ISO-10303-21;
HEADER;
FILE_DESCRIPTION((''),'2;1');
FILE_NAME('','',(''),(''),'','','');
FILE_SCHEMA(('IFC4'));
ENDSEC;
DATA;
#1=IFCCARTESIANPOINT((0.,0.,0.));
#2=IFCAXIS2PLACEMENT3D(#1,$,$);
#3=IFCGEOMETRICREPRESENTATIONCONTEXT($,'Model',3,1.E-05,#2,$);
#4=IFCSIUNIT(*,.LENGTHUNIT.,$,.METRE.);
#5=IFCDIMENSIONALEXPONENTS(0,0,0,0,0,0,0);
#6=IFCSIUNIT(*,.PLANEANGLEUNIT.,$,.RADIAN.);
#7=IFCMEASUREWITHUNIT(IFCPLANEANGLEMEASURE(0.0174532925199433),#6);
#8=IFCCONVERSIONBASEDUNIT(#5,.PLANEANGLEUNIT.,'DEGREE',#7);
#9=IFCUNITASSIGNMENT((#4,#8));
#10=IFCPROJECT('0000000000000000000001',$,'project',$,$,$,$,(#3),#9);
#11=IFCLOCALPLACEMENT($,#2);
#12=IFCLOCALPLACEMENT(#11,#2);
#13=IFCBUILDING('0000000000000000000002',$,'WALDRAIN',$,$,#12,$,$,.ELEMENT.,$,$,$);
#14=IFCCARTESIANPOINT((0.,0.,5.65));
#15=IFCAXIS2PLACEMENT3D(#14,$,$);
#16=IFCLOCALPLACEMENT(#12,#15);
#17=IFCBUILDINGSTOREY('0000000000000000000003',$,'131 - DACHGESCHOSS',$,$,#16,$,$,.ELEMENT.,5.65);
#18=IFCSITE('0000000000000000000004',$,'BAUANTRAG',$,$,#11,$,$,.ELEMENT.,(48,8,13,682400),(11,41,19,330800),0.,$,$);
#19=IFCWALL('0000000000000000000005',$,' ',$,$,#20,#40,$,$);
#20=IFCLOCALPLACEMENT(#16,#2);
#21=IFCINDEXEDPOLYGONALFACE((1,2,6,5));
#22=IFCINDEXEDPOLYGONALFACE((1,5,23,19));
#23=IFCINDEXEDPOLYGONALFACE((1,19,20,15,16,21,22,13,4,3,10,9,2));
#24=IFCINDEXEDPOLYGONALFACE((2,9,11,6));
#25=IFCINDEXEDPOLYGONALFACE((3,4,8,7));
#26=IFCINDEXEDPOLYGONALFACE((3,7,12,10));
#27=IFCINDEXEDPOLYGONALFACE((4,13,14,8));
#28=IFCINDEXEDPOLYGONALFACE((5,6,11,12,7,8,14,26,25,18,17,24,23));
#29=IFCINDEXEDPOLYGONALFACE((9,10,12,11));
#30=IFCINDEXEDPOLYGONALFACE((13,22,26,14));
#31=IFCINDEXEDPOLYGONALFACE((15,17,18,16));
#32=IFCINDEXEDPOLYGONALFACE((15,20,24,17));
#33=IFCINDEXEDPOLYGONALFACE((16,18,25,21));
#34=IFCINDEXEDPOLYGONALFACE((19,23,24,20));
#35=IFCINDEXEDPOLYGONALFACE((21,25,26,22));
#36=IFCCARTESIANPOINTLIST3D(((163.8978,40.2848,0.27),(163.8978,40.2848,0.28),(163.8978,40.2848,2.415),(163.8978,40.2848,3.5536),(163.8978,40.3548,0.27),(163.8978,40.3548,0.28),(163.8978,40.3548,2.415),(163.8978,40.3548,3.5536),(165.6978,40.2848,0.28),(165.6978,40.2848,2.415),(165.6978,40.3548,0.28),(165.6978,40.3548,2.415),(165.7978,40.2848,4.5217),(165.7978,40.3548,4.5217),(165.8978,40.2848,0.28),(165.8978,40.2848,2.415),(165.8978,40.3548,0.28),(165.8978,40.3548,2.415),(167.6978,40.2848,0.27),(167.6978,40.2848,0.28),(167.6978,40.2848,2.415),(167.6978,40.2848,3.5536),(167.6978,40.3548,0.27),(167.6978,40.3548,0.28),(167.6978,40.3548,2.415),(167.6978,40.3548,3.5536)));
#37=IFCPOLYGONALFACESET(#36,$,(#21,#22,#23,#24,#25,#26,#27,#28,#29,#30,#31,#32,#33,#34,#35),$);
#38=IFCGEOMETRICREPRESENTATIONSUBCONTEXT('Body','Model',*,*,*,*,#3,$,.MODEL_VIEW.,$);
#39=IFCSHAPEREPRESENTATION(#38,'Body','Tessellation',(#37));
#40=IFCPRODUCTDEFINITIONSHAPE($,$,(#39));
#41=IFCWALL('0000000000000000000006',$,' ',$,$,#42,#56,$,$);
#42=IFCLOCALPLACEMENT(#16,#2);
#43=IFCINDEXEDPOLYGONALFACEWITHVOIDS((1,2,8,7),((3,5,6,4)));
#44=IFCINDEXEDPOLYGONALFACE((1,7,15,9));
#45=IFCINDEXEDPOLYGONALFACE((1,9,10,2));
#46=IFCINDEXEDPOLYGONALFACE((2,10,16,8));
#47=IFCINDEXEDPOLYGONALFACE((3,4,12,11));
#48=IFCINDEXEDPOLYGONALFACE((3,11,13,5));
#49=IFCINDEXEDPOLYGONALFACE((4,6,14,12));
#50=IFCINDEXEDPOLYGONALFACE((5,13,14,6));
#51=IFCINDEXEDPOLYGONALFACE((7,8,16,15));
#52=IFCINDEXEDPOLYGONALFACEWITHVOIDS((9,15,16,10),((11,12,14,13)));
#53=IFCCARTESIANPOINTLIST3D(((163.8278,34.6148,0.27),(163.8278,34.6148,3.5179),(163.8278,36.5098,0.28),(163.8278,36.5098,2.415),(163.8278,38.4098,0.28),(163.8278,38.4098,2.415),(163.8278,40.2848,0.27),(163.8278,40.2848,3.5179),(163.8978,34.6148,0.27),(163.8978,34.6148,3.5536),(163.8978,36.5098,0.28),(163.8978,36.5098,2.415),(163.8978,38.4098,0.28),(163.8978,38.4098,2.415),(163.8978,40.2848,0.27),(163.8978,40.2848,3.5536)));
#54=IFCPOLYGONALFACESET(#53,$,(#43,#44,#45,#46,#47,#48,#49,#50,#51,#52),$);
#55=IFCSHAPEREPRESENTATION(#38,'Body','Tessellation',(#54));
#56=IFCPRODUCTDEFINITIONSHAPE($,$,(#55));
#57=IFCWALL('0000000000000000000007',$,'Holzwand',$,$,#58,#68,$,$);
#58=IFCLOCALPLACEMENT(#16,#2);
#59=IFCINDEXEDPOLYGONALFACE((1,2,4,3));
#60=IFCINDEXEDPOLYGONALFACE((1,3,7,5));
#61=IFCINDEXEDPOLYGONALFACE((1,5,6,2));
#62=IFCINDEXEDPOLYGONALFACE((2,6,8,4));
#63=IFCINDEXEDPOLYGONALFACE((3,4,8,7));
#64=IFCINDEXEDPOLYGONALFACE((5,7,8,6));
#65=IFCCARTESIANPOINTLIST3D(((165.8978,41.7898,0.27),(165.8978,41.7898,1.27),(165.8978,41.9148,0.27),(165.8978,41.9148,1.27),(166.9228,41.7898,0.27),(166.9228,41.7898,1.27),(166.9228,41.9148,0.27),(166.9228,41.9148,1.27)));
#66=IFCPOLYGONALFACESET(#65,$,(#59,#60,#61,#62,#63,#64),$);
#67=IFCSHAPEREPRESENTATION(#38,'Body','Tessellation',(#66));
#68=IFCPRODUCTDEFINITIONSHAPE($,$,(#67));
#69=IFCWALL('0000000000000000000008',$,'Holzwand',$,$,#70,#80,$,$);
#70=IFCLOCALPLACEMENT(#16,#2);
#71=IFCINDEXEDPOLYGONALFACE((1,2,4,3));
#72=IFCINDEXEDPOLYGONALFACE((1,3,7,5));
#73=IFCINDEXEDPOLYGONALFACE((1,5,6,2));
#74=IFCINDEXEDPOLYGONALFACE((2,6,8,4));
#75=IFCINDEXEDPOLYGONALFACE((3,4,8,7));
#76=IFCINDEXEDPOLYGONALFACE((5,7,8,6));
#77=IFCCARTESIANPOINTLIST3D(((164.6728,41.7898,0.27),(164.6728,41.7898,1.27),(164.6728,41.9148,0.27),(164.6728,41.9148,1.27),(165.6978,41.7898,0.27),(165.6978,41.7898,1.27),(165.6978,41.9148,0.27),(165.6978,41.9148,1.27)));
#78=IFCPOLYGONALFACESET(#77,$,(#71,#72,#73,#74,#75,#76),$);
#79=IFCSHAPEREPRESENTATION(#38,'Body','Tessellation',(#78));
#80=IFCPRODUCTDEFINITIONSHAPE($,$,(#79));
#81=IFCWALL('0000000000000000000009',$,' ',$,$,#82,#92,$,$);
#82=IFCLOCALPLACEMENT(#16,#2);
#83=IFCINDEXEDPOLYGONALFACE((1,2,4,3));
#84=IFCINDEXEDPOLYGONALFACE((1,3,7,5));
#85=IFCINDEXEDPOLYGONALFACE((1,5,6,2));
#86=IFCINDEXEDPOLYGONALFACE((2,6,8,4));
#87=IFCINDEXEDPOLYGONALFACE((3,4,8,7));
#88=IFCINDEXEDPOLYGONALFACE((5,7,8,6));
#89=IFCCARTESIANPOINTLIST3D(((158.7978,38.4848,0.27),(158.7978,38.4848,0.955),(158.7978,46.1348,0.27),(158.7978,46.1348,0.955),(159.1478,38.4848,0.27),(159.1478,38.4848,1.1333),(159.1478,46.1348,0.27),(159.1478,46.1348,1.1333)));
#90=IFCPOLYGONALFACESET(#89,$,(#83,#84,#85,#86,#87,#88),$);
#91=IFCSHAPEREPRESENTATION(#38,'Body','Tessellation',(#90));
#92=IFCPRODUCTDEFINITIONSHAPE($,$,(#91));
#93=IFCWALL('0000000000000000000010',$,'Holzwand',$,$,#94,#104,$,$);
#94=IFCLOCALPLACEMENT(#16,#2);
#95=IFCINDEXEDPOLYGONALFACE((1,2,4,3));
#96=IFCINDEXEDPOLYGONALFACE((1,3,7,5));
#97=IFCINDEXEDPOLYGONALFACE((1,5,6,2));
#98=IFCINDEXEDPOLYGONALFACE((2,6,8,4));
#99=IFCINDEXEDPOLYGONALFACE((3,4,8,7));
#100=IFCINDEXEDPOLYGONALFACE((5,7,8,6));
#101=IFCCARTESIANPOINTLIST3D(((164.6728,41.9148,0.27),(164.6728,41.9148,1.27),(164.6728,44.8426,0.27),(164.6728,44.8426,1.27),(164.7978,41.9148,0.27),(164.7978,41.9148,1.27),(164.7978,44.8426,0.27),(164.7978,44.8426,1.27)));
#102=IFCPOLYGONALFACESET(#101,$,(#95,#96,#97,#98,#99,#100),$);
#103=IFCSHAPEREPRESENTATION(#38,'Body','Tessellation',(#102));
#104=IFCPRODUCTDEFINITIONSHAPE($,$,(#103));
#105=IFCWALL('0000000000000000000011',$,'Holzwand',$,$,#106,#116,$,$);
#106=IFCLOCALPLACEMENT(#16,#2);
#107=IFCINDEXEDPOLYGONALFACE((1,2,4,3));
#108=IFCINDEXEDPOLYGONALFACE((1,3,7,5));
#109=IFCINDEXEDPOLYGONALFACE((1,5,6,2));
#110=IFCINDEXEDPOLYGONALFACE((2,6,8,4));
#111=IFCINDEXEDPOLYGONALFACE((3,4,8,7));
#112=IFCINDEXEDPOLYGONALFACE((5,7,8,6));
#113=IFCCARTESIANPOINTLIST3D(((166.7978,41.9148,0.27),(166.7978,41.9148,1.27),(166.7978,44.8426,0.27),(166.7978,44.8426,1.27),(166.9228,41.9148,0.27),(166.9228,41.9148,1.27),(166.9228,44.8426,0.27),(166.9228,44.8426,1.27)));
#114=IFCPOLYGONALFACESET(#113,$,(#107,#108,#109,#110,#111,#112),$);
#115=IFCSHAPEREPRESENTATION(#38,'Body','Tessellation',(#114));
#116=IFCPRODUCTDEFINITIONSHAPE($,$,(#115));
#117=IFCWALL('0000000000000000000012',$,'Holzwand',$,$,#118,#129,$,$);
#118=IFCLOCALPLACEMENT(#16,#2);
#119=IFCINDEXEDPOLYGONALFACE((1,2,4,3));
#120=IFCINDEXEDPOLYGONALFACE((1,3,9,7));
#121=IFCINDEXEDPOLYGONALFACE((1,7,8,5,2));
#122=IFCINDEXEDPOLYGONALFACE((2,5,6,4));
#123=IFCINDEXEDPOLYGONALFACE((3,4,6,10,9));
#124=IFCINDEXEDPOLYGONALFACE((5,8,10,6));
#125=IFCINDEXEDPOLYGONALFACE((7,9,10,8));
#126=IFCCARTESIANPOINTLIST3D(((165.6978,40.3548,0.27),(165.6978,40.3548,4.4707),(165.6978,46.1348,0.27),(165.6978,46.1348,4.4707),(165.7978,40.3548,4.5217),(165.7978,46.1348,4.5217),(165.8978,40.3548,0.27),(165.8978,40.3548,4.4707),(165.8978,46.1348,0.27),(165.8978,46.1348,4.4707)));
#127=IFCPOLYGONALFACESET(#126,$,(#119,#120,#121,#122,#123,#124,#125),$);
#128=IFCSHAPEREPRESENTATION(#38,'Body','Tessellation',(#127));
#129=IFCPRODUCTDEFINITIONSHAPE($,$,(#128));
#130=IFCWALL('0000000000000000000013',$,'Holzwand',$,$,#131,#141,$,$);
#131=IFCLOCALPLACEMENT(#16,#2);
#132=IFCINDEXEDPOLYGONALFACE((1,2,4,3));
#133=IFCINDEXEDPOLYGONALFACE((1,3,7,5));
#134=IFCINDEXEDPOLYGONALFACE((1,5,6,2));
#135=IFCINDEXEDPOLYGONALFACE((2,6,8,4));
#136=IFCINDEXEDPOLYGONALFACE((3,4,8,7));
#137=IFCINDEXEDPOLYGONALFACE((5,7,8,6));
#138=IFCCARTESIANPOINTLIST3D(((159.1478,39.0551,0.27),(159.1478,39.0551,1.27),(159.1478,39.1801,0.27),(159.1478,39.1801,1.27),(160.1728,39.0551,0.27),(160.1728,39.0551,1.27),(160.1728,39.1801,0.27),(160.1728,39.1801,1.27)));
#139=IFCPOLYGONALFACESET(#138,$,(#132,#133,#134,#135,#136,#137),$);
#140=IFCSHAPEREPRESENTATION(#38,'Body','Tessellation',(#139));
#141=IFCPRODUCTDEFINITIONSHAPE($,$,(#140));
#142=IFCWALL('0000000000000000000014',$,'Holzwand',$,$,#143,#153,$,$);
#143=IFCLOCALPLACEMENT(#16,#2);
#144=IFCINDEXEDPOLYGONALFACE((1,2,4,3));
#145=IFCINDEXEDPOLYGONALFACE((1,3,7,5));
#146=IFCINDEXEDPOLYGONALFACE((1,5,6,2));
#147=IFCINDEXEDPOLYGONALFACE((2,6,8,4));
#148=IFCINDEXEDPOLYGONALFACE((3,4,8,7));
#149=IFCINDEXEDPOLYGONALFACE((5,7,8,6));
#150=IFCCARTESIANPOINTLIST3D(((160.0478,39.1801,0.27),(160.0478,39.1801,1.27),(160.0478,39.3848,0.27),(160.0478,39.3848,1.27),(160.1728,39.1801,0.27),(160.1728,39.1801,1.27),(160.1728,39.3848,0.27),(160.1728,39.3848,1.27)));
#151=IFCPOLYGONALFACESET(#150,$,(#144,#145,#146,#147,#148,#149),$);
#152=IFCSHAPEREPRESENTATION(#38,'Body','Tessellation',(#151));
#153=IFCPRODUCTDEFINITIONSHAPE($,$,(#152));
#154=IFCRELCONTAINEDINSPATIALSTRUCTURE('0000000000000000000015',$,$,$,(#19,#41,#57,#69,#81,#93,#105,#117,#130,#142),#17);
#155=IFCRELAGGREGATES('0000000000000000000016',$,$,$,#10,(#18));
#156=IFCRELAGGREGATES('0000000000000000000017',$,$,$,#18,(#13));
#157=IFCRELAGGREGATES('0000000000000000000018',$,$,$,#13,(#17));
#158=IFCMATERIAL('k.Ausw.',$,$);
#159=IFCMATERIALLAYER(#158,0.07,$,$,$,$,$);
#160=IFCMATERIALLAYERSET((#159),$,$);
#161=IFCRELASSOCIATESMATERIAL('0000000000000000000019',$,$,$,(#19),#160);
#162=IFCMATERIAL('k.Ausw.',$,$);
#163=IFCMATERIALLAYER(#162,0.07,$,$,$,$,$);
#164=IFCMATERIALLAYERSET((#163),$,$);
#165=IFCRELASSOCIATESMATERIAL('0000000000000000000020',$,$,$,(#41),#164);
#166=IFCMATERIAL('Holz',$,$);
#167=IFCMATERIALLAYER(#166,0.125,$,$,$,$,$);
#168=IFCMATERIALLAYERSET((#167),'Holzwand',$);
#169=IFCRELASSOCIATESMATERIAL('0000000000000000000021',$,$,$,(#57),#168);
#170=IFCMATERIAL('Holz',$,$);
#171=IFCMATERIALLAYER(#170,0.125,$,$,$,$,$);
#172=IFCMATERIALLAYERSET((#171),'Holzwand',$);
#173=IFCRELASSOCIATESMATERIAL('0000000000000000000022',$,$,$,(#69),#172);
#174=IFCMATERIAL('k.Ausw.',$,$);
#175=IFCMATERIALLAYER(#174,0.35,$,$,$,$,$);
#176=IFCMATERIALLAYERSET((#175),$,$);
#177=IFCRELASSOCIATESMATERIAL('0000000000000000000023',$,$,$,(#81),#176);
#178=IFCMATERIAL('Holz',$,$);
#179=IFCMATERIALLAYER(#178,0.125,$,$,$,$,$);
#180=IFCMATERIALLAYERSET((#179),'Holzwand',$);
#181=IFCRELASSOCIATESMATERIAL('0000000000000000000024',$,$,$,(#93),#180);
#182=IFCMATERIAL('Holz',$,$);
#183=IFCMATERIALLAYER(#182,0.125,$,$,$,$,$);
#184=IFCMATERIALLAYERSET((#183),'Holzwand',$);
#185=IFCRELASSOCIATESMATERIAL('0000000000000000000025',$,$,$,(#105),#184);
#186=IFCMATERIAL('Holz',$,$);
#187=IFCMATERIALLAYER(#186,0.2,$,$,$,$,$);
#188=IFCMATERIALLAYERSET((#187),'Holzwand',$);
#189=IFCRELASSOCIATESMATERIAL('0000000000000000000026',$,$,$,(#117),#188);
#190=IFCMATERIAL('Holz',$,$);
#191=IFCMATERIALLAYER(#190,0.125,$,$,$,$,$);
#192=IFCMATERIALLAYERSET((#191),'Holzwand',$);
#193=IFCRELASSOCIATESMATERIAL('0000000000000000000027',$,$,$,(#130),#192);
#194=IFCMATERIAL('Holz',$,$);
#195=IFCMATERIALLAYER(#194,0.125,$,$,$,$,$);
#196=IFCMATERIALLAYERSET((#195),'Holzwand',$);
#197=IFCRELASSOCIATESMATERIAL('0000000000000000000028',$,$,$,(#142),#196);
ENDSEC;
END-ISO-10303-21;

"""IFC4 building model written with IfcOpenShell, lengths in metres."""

from ifc_helpers import new_model, entity, si_unit, converted_unit, frame, frame_2d, origin, origin_with_axes, place, context, subcontext, project, spatial, polyline, rectangle, outline, extrude, clip, halfspace, bounded_halfspace, material, layer, layer_set, layer_usage, element, save


model = new_model("IFC4")

# Units and contexts
model_context = context("Model", 3, precision=1e-05, world=origin())
body_context = subcontext(model_context, "Body", "Model", "MODEL_VIEW")
ifc_project = project(units=[si_unit("LENGTHUNIT", "METRE"), converted_unit("PLANEANGLEUNIT", "DEGREE", entity("IfcPlaneAngleMeasure", 0.0174532925199433), si_unit("PLANEANGLEUNIT", "RADIAN"), dimensions=[0, 0, 0, 0, 0, 0, 0])], contexts=[model_context])

# Site, building, storey
site_placement = place(None, origin())
site = spatial("IfcSite", under=ifc_project, at=site_placement, Name="BAUANTRAG", CompositionType="ELEMENT", RefLatitude=(48, 8, 13, 682400), RefLongitude=(11, 41, 19, 330800), RefElevation=0.0)
building_placement = place(site_placement, origin())
building = spatial("IfcBuilding", under=site, at=building_placement, Name="WALDRAIN", CompositionType="ELEMENT")
storey_placement = place(building_placement, frame((0.0, 0.0, 5.65)))
storey = spatial("IfcBuildingStorey", under=building, at=storey_placement, Name="131 - DACHGESCHOSS", CompositionType="ELEMENT", Elevation=5.65)

# Wall, openings
ifc_material_1 = material(Name="k.Ausw.")
ifc_layer_1 = layer(ifc_material_1, 0.07)
ifc_layer_set_1 = layer_set([ifc_layer_1])
ifc_layer_usage_1 = layer_usage(ifc_layer_set_1, "AXIS2", "POSITIVE", 0.0)
wall_1_placement = place(storey_placement, frame((167.6978, 40.3548, 0.27), z_axis=(0.0, 0.0, 1.0), x_axis=(-1.0, 0.0, 0.0)))
wall_1 = element("IfcWall", 1, at=wall_1_placement, inside=storey, material=ifc_layer_usage_1, Name=" ", context=body_context, shape_type="Clipping", body=[
    clip(clip(extrude(rectangle(XDim=3.8, YDim=0.07, at=frame_2d((1.9, 0.035), x_axis=(1.0, 0.0))), origin_with_axes(), (0.0, 0.0, 1.0), 4.2517), bounded_halfspace(frame((2.85, 0.035, 3.7676), z_axis=(-0.45399, 0.0, -0.891007), x_axis=(-0.891007, 0.0, 0.45399)), True, origin_with_axes(), polyline([(3.8, 0.07), (1.9, 0.07), (1.9, 0.0), (3.8, 0.0), (3.8, 0.07)]))), bounded_halfspace(frame((0.95, 0.035, 3.7676), z_axis=(0.45399, 0.0, -0.891007), x_axis=(0.891007, 0.0, 0.45399)), True, origin_with_axes(), polyline([(0.0, 0.0), (1.9, 0.0), (1.9, 0.07), (0.0, 0.07), (0.0, 0.0)]))),
])
opening_1_placement = place(wall_1_placement, frame((0.0, 0.0, 0.01), z_axis=(0.0, 1.0, 0.0), x_axis=(0.0, 0.0, 1.0)))
element("IfcOpeningElement", 2, at=opening_1_placement, cuts=wall_1, ObjectType="Opening", context=body_context, shape_type="SweptSolid", body=[
    extrude(outline(polyline([(0.0, 1.8), (2.135, 1.8), (2.135, 0.0), (0.0, 0.0), (0.0, 1.8)])), origin_with_axes(), (0.0, 0.0, 1.0), 0.07),
])
opening_2_placement = place(wall_1_placement, frame((2.0, 0.0, 0.01), z_axis=(0.0, 1.0, 0.0), x_axis=(0.0, 0.0, 1.0)))
element("IfcOpeningElement", 3, at=opening_2_placement, cuts=wall_1, ObjectType="Opening", context=body_context, shape_type="SweptSolid", body=[
    extrude(outline(polyline([(0.0, 1.8), (2.135, 1.8), (2.135, 0.0), (0.0, 0.0), (0.0, 1.8)])), origin_with_axes(), (0.0, 0.0, 1.0), 0.07),
])

# Wall, opening
ifc_material_2 = material(Name="k.Ausw.")
ifc_layer_2 = layer(ifc_material_2, 0.07)
ifc_layer_set_2 = layer_set([ifc_layer_2])
ifc_layer_usage_2 = layer_usage(ifc_layer_set_2, "AXIS2", "POSITIVE", 0.0)
wall_2_placement = place(storey_placement, frame((163.8278, 40.2848, 0.27), z_axis=(0.0, 0.0, 1.0), x_axis=(0.0, -1.0, 0.0)))
wall_2 = element("IfcWall", 4, at=wall_2_placement, inside=storey, material=ifc_layer_usage_2, Name=" ", context=body_context, shape_type="Clipping", body=[
    clip(extrude(rectangle(XDim=5.67, YDim=0.07, at=frame_2d((2.835, 0.035), x_axis=(1.0, 0.0))), origin_with_axes(), (0.0, 0.0, 1.0), 3.2836), halfspace(frame((2.835, 0.035, 3.2657), z_axis=(0.0, 0.45399, -0.891007), x_axis=(1.0, 0.0, 0.0)), True)),
])
opening_3_placement = place(wall_2_placement, frame((3.775, 0.07, 0.01), z_axis=(0.0, -1.0, 0.0), x_axis=(0.0, 0.0, 1.0)))
element("IfcOpeningElement", 5, at=opening_3_placement, cuts=wall_2, ObjectType="Opening", context=body_context, shape_type="SweptSolid", body=[
    extrude(outline(polyline([(0.0, 1.9), (2.135, 1.9), (2.135, 0.0), (0.0, 0.0), (0.0, 1.9)])), origin_with_axes(), (0.0, 0.0, 1.0), 0.07),
])

# Walls
ifc_material_3 = material(Name="Holz")
ifc_layer_3 = layer(ifc_material_3, 0.125)
ifc_layer_set_3 = layer_set([ifc_layer_3], Name="Holzwand")
ifc_layer_usage_3 = layer_usage(ifc_layer_set_3, "AXIS2", "POSITIVE", 0.0)
wall_3_placement = place(storey_placement, frame((166.9228, 41.9148, 0.27), z_axis=(0.0, 0.0, 1.0), x_axis=(-1.0, 0.0, 0.0)))
element("IfcWall", 6, at=wall_3_placement, inside=storey, material=ifc_layer_usage_3, Name="Holzwand", context=body_context, shape_type="SweptSolid", body=[
    extrude(rectangle(XDim=1.025, YDim=0.125, at=frame_2d((0.5125, 0.0625), x_axis=(1.0, 0.0))), origin_with_axes(), (0.0, 0.0, 1.0), 1.0),
])
ifc_material_4 = material(Name="Holz")
ifc_layer_4 = layer(ifc_material_4, 0.125)
ifc_layer_set_4 = layer_set([ifc_layer_4], Name="Holzwand")
ifc_layer_usage_4 = layer_usage(ifc_layer_set_4, "AXIS2", "POSITIVE", 0.0)
wall_4_placement = place(storey_placement, frame((165.6978, 41.9148, 0.27), z_axis=(0.0, 0.0, 1.0), x_axis=(-1.0, 0.0, 0.0)))
element("IfcWall", 7, at=wall_4_placement, inside=storey, material=ifc_layer_usage_4, Name="Holzwand", context=body_context, shape_type="SweptSolid", body=[
    extrude(rectangle(XDim=1.025, YDim=0.125, at=frame_2d((0.5125, 0.0625), x_axis=(1.0, 0.0))), origin_with_axes(), (0.0, 0.0, 1.0), 1.0),
])
ifc_material_5 = material(Name="k.Ausw.")
ifc_layer_5 = layer(ifc_material_5, 0.35)
ifc_layer_set_5 = layer_set([ifc_layer_5])
ifc_layer_usage_5 = layer_usage(ifc_layer_set_5, "AXIS2", "POSITIVE", 0.0)
wall_5_placement = place(storey_placement, frame((158.7978, 46.1348, 0.27), z_axis=(0.0, 0.0, 1.0), x_axis=(0.0, -1.0, 0.0)))
element("IfcWall", 8, at=wall_5_placement, inside=storey, material=ifc_layer_usage_5, Name=" ", context=body_context, shape_type="Clipping", body=[
    clip(extrude(rectangle(XDim=7.65, YDim=0.35, at=frame_2d((3.825, 0.175), x_axis=(1.0, 0.0))), origin_with_axes(), (0.0, 0.0, 1.0), 0.8633), halfspace(frame((3.825, 0.175, 0.7742), z_axis=(0.0, 0.45399, -0.891007), x_axis=(0.0, -0.891007, -0.45399)), True)),
])
ifc_material_6 = material(Name="Holz")
ifc_layer_6 = layer(ifc_material_6, 0.125)
ifc_layer_set_6 = layer_set([ifc_layer_6], Name="Holzwand")
ifc_layer_usage_6 = layer_usage(ifc_layer_set_6, "AXIS2", "POSITIVE", 0.0)
wall_6_placement = place(storey_placement, frame((164.7978, 41.9148, 0.27), z_axis=(0.0, 0.0, 1.0), x_axis=(0.0, 1.0, 0.0)))
element("IfcWall", 9, at=wall_6_placement, inside=storey, material=ifc_layer_usage_6, Name="Holzwand", context=body_context, shape_type="SweptSolid", body=[
    extrude(rectangle(XDim=2.9278, YDim=0.125, at=frame_2d((1.4639, 0.0625), x_axis=(1.0, 0.0))), origin_with_axes(), (0.0, 0.0, 1.0), 1.0),
])
ifc_material_7 = material(Name="Holz")
ifc_layer_7 = layer(ifc_material_7, 0.125)
ifc_layer_set_7 = layer_set([ifc_layer_7], Name="Holzwand")
ifc_layer_usage_7 = layer_usage(ifc_layer_set_7, "AXIS2", "POSITIVE", 0.0)
wall_7_placement = place(storey_placement, frame((166.7978, 44.8426, 0.27), z_axis=(0.0, 0.0, 1.0), x_axis=(0.0, -1.0, 0.0)))
element("IfcWall", 10, at=wall_7_placement, inside=storey, material=ifc_layer_usage_7, Name="Holzwand", context=body_context, shape_type="SweptSolid", body=[
    extrude(rectangle(XDim=2.9278, YDim=0.125, at=frame_2d((1.4639, 0.0625), x_axis=(1.0, 0.0))), origin_with_axes(), (0.0, 0.0, 1.0), 1.0),
])
ifc_material_8 = material(Name="Holz")
ifc_layer_8 = layer(ifc_material_8, 0.2)
ifc_layer_set_8 = layer_set([ifc_layer_8], Name="Holzwand")
ifc_layer_usage_8 = layer_usage(ifc_layer_set_8, "AXIS2", "POSITIVE", 0.0)
wall_8_placement = place(storey_placement, frame((165.6978, 46.1348, 0.27), z_axis=(0.0, 0.0, 1.0), x_axis=(0.0, -1.0, 0.0)))
element("IfcWall", 11, at=wall_8_placement, inside=storey, material=ifc_layer_usage_8, Name="Holzwand", context=body_context, shape_type="Clipping", body=[
    clip(clip(extrude(rectangle(XDim=5.78, YDim=0.2, at=frame_2d((2.89, 0.1), x_axis=(1.0, 0.0))), origin_with_axes(), (0.0, 0.0, 1.0), 4.2517), bounded_halfspace(frame((2.89, 0.05, 4.2262), z_axis=(0.0, 0.45399, -0.891007), x_axis=(0.0, 0.891007, 0.45399)), True, origin_with_axes(), polyline([(5.78, 0.0), (5.78, 0.1), (0.0, 0.1), (0.0, 0.0), (5.78, 0.0)]))), bounded_halfspace(frame((2.89, 0.15, 4.2262), z_axis=(0.0, -0.45399, -0.891007), x_axis=(0.0, -0.891007, 0.45399)), True, origin_with_axes(), polyline([(0.0, 0.2), (0.0, 0.1), (5.78, 0.1), (5.78, 0.2), (0.0, 0.2)]))),
])
ifc_material_9 = material(Name="Holz")
ifc_layer_9 = layer(ifc_material_9, 0.125)
ifc_layer_set_9 = layer_set([ifc_layer_9], Name="Holzwand")
ifc_layer_usage_9 = layer_usage(ifc_layer_set_9, "AXIS2", "POSITIVE", 0.0)
wall_9_placement = place(storey_placement, frame((160.1728, 39.1801, 0.27), z_axis=(0.0, 0.0, 1.0), x_axis=(-1.0, 0.0, 0.0)))
element("IfcWall", 12, at=wall_9_placement, inside=storey, material=ifc_layer_usage_9, Name="Holzwand", context=body_context, shape_type="SweptSolid", body=[
    extrude(rectangle(XDim=1.025, YDim=0.125, at=frame_2d((0.5125, 0.0625), x_axis=(1.0, 0.0))), origin_with_axes(), (0.0, 0.0, 1.0), 1.0),
])
ifc_material_10 = material(Name="Holz")
ifc_layer_10 = layer(ifc_material_10, 0.125)
ifc_layer_set_10 = layer_set([ifc_layer_10], Name="Holzwand")
ifc_layer_usage_10 = layer_usage(ifc_layer_set_10, "AXIS2", "POSITIVE", 0.0)
wall_10_placement = place(storey_placement, frame((160.0478, 39.3848, 0.27), z_axis=(0.0, 0.0, 1.0), x_axis=(0.0, -1.0, 0.0)))
element("IfcWall", 13, at=wall_10_placement, inside=storey, material=ifc_layer_usage_10, Name="Holzwand", context=body_context, shape_type="SweptSolid", body=[
    extrude(rectangle(XDim=0.2047, YDim=0.125, at=frame_2d((0.1024, 0.0625), x_axis=(1.0, 0.0))), origin_with_axes(), (0.0, 0.0, 1.0), 1.0),
])

save(model, "model.ifc")
